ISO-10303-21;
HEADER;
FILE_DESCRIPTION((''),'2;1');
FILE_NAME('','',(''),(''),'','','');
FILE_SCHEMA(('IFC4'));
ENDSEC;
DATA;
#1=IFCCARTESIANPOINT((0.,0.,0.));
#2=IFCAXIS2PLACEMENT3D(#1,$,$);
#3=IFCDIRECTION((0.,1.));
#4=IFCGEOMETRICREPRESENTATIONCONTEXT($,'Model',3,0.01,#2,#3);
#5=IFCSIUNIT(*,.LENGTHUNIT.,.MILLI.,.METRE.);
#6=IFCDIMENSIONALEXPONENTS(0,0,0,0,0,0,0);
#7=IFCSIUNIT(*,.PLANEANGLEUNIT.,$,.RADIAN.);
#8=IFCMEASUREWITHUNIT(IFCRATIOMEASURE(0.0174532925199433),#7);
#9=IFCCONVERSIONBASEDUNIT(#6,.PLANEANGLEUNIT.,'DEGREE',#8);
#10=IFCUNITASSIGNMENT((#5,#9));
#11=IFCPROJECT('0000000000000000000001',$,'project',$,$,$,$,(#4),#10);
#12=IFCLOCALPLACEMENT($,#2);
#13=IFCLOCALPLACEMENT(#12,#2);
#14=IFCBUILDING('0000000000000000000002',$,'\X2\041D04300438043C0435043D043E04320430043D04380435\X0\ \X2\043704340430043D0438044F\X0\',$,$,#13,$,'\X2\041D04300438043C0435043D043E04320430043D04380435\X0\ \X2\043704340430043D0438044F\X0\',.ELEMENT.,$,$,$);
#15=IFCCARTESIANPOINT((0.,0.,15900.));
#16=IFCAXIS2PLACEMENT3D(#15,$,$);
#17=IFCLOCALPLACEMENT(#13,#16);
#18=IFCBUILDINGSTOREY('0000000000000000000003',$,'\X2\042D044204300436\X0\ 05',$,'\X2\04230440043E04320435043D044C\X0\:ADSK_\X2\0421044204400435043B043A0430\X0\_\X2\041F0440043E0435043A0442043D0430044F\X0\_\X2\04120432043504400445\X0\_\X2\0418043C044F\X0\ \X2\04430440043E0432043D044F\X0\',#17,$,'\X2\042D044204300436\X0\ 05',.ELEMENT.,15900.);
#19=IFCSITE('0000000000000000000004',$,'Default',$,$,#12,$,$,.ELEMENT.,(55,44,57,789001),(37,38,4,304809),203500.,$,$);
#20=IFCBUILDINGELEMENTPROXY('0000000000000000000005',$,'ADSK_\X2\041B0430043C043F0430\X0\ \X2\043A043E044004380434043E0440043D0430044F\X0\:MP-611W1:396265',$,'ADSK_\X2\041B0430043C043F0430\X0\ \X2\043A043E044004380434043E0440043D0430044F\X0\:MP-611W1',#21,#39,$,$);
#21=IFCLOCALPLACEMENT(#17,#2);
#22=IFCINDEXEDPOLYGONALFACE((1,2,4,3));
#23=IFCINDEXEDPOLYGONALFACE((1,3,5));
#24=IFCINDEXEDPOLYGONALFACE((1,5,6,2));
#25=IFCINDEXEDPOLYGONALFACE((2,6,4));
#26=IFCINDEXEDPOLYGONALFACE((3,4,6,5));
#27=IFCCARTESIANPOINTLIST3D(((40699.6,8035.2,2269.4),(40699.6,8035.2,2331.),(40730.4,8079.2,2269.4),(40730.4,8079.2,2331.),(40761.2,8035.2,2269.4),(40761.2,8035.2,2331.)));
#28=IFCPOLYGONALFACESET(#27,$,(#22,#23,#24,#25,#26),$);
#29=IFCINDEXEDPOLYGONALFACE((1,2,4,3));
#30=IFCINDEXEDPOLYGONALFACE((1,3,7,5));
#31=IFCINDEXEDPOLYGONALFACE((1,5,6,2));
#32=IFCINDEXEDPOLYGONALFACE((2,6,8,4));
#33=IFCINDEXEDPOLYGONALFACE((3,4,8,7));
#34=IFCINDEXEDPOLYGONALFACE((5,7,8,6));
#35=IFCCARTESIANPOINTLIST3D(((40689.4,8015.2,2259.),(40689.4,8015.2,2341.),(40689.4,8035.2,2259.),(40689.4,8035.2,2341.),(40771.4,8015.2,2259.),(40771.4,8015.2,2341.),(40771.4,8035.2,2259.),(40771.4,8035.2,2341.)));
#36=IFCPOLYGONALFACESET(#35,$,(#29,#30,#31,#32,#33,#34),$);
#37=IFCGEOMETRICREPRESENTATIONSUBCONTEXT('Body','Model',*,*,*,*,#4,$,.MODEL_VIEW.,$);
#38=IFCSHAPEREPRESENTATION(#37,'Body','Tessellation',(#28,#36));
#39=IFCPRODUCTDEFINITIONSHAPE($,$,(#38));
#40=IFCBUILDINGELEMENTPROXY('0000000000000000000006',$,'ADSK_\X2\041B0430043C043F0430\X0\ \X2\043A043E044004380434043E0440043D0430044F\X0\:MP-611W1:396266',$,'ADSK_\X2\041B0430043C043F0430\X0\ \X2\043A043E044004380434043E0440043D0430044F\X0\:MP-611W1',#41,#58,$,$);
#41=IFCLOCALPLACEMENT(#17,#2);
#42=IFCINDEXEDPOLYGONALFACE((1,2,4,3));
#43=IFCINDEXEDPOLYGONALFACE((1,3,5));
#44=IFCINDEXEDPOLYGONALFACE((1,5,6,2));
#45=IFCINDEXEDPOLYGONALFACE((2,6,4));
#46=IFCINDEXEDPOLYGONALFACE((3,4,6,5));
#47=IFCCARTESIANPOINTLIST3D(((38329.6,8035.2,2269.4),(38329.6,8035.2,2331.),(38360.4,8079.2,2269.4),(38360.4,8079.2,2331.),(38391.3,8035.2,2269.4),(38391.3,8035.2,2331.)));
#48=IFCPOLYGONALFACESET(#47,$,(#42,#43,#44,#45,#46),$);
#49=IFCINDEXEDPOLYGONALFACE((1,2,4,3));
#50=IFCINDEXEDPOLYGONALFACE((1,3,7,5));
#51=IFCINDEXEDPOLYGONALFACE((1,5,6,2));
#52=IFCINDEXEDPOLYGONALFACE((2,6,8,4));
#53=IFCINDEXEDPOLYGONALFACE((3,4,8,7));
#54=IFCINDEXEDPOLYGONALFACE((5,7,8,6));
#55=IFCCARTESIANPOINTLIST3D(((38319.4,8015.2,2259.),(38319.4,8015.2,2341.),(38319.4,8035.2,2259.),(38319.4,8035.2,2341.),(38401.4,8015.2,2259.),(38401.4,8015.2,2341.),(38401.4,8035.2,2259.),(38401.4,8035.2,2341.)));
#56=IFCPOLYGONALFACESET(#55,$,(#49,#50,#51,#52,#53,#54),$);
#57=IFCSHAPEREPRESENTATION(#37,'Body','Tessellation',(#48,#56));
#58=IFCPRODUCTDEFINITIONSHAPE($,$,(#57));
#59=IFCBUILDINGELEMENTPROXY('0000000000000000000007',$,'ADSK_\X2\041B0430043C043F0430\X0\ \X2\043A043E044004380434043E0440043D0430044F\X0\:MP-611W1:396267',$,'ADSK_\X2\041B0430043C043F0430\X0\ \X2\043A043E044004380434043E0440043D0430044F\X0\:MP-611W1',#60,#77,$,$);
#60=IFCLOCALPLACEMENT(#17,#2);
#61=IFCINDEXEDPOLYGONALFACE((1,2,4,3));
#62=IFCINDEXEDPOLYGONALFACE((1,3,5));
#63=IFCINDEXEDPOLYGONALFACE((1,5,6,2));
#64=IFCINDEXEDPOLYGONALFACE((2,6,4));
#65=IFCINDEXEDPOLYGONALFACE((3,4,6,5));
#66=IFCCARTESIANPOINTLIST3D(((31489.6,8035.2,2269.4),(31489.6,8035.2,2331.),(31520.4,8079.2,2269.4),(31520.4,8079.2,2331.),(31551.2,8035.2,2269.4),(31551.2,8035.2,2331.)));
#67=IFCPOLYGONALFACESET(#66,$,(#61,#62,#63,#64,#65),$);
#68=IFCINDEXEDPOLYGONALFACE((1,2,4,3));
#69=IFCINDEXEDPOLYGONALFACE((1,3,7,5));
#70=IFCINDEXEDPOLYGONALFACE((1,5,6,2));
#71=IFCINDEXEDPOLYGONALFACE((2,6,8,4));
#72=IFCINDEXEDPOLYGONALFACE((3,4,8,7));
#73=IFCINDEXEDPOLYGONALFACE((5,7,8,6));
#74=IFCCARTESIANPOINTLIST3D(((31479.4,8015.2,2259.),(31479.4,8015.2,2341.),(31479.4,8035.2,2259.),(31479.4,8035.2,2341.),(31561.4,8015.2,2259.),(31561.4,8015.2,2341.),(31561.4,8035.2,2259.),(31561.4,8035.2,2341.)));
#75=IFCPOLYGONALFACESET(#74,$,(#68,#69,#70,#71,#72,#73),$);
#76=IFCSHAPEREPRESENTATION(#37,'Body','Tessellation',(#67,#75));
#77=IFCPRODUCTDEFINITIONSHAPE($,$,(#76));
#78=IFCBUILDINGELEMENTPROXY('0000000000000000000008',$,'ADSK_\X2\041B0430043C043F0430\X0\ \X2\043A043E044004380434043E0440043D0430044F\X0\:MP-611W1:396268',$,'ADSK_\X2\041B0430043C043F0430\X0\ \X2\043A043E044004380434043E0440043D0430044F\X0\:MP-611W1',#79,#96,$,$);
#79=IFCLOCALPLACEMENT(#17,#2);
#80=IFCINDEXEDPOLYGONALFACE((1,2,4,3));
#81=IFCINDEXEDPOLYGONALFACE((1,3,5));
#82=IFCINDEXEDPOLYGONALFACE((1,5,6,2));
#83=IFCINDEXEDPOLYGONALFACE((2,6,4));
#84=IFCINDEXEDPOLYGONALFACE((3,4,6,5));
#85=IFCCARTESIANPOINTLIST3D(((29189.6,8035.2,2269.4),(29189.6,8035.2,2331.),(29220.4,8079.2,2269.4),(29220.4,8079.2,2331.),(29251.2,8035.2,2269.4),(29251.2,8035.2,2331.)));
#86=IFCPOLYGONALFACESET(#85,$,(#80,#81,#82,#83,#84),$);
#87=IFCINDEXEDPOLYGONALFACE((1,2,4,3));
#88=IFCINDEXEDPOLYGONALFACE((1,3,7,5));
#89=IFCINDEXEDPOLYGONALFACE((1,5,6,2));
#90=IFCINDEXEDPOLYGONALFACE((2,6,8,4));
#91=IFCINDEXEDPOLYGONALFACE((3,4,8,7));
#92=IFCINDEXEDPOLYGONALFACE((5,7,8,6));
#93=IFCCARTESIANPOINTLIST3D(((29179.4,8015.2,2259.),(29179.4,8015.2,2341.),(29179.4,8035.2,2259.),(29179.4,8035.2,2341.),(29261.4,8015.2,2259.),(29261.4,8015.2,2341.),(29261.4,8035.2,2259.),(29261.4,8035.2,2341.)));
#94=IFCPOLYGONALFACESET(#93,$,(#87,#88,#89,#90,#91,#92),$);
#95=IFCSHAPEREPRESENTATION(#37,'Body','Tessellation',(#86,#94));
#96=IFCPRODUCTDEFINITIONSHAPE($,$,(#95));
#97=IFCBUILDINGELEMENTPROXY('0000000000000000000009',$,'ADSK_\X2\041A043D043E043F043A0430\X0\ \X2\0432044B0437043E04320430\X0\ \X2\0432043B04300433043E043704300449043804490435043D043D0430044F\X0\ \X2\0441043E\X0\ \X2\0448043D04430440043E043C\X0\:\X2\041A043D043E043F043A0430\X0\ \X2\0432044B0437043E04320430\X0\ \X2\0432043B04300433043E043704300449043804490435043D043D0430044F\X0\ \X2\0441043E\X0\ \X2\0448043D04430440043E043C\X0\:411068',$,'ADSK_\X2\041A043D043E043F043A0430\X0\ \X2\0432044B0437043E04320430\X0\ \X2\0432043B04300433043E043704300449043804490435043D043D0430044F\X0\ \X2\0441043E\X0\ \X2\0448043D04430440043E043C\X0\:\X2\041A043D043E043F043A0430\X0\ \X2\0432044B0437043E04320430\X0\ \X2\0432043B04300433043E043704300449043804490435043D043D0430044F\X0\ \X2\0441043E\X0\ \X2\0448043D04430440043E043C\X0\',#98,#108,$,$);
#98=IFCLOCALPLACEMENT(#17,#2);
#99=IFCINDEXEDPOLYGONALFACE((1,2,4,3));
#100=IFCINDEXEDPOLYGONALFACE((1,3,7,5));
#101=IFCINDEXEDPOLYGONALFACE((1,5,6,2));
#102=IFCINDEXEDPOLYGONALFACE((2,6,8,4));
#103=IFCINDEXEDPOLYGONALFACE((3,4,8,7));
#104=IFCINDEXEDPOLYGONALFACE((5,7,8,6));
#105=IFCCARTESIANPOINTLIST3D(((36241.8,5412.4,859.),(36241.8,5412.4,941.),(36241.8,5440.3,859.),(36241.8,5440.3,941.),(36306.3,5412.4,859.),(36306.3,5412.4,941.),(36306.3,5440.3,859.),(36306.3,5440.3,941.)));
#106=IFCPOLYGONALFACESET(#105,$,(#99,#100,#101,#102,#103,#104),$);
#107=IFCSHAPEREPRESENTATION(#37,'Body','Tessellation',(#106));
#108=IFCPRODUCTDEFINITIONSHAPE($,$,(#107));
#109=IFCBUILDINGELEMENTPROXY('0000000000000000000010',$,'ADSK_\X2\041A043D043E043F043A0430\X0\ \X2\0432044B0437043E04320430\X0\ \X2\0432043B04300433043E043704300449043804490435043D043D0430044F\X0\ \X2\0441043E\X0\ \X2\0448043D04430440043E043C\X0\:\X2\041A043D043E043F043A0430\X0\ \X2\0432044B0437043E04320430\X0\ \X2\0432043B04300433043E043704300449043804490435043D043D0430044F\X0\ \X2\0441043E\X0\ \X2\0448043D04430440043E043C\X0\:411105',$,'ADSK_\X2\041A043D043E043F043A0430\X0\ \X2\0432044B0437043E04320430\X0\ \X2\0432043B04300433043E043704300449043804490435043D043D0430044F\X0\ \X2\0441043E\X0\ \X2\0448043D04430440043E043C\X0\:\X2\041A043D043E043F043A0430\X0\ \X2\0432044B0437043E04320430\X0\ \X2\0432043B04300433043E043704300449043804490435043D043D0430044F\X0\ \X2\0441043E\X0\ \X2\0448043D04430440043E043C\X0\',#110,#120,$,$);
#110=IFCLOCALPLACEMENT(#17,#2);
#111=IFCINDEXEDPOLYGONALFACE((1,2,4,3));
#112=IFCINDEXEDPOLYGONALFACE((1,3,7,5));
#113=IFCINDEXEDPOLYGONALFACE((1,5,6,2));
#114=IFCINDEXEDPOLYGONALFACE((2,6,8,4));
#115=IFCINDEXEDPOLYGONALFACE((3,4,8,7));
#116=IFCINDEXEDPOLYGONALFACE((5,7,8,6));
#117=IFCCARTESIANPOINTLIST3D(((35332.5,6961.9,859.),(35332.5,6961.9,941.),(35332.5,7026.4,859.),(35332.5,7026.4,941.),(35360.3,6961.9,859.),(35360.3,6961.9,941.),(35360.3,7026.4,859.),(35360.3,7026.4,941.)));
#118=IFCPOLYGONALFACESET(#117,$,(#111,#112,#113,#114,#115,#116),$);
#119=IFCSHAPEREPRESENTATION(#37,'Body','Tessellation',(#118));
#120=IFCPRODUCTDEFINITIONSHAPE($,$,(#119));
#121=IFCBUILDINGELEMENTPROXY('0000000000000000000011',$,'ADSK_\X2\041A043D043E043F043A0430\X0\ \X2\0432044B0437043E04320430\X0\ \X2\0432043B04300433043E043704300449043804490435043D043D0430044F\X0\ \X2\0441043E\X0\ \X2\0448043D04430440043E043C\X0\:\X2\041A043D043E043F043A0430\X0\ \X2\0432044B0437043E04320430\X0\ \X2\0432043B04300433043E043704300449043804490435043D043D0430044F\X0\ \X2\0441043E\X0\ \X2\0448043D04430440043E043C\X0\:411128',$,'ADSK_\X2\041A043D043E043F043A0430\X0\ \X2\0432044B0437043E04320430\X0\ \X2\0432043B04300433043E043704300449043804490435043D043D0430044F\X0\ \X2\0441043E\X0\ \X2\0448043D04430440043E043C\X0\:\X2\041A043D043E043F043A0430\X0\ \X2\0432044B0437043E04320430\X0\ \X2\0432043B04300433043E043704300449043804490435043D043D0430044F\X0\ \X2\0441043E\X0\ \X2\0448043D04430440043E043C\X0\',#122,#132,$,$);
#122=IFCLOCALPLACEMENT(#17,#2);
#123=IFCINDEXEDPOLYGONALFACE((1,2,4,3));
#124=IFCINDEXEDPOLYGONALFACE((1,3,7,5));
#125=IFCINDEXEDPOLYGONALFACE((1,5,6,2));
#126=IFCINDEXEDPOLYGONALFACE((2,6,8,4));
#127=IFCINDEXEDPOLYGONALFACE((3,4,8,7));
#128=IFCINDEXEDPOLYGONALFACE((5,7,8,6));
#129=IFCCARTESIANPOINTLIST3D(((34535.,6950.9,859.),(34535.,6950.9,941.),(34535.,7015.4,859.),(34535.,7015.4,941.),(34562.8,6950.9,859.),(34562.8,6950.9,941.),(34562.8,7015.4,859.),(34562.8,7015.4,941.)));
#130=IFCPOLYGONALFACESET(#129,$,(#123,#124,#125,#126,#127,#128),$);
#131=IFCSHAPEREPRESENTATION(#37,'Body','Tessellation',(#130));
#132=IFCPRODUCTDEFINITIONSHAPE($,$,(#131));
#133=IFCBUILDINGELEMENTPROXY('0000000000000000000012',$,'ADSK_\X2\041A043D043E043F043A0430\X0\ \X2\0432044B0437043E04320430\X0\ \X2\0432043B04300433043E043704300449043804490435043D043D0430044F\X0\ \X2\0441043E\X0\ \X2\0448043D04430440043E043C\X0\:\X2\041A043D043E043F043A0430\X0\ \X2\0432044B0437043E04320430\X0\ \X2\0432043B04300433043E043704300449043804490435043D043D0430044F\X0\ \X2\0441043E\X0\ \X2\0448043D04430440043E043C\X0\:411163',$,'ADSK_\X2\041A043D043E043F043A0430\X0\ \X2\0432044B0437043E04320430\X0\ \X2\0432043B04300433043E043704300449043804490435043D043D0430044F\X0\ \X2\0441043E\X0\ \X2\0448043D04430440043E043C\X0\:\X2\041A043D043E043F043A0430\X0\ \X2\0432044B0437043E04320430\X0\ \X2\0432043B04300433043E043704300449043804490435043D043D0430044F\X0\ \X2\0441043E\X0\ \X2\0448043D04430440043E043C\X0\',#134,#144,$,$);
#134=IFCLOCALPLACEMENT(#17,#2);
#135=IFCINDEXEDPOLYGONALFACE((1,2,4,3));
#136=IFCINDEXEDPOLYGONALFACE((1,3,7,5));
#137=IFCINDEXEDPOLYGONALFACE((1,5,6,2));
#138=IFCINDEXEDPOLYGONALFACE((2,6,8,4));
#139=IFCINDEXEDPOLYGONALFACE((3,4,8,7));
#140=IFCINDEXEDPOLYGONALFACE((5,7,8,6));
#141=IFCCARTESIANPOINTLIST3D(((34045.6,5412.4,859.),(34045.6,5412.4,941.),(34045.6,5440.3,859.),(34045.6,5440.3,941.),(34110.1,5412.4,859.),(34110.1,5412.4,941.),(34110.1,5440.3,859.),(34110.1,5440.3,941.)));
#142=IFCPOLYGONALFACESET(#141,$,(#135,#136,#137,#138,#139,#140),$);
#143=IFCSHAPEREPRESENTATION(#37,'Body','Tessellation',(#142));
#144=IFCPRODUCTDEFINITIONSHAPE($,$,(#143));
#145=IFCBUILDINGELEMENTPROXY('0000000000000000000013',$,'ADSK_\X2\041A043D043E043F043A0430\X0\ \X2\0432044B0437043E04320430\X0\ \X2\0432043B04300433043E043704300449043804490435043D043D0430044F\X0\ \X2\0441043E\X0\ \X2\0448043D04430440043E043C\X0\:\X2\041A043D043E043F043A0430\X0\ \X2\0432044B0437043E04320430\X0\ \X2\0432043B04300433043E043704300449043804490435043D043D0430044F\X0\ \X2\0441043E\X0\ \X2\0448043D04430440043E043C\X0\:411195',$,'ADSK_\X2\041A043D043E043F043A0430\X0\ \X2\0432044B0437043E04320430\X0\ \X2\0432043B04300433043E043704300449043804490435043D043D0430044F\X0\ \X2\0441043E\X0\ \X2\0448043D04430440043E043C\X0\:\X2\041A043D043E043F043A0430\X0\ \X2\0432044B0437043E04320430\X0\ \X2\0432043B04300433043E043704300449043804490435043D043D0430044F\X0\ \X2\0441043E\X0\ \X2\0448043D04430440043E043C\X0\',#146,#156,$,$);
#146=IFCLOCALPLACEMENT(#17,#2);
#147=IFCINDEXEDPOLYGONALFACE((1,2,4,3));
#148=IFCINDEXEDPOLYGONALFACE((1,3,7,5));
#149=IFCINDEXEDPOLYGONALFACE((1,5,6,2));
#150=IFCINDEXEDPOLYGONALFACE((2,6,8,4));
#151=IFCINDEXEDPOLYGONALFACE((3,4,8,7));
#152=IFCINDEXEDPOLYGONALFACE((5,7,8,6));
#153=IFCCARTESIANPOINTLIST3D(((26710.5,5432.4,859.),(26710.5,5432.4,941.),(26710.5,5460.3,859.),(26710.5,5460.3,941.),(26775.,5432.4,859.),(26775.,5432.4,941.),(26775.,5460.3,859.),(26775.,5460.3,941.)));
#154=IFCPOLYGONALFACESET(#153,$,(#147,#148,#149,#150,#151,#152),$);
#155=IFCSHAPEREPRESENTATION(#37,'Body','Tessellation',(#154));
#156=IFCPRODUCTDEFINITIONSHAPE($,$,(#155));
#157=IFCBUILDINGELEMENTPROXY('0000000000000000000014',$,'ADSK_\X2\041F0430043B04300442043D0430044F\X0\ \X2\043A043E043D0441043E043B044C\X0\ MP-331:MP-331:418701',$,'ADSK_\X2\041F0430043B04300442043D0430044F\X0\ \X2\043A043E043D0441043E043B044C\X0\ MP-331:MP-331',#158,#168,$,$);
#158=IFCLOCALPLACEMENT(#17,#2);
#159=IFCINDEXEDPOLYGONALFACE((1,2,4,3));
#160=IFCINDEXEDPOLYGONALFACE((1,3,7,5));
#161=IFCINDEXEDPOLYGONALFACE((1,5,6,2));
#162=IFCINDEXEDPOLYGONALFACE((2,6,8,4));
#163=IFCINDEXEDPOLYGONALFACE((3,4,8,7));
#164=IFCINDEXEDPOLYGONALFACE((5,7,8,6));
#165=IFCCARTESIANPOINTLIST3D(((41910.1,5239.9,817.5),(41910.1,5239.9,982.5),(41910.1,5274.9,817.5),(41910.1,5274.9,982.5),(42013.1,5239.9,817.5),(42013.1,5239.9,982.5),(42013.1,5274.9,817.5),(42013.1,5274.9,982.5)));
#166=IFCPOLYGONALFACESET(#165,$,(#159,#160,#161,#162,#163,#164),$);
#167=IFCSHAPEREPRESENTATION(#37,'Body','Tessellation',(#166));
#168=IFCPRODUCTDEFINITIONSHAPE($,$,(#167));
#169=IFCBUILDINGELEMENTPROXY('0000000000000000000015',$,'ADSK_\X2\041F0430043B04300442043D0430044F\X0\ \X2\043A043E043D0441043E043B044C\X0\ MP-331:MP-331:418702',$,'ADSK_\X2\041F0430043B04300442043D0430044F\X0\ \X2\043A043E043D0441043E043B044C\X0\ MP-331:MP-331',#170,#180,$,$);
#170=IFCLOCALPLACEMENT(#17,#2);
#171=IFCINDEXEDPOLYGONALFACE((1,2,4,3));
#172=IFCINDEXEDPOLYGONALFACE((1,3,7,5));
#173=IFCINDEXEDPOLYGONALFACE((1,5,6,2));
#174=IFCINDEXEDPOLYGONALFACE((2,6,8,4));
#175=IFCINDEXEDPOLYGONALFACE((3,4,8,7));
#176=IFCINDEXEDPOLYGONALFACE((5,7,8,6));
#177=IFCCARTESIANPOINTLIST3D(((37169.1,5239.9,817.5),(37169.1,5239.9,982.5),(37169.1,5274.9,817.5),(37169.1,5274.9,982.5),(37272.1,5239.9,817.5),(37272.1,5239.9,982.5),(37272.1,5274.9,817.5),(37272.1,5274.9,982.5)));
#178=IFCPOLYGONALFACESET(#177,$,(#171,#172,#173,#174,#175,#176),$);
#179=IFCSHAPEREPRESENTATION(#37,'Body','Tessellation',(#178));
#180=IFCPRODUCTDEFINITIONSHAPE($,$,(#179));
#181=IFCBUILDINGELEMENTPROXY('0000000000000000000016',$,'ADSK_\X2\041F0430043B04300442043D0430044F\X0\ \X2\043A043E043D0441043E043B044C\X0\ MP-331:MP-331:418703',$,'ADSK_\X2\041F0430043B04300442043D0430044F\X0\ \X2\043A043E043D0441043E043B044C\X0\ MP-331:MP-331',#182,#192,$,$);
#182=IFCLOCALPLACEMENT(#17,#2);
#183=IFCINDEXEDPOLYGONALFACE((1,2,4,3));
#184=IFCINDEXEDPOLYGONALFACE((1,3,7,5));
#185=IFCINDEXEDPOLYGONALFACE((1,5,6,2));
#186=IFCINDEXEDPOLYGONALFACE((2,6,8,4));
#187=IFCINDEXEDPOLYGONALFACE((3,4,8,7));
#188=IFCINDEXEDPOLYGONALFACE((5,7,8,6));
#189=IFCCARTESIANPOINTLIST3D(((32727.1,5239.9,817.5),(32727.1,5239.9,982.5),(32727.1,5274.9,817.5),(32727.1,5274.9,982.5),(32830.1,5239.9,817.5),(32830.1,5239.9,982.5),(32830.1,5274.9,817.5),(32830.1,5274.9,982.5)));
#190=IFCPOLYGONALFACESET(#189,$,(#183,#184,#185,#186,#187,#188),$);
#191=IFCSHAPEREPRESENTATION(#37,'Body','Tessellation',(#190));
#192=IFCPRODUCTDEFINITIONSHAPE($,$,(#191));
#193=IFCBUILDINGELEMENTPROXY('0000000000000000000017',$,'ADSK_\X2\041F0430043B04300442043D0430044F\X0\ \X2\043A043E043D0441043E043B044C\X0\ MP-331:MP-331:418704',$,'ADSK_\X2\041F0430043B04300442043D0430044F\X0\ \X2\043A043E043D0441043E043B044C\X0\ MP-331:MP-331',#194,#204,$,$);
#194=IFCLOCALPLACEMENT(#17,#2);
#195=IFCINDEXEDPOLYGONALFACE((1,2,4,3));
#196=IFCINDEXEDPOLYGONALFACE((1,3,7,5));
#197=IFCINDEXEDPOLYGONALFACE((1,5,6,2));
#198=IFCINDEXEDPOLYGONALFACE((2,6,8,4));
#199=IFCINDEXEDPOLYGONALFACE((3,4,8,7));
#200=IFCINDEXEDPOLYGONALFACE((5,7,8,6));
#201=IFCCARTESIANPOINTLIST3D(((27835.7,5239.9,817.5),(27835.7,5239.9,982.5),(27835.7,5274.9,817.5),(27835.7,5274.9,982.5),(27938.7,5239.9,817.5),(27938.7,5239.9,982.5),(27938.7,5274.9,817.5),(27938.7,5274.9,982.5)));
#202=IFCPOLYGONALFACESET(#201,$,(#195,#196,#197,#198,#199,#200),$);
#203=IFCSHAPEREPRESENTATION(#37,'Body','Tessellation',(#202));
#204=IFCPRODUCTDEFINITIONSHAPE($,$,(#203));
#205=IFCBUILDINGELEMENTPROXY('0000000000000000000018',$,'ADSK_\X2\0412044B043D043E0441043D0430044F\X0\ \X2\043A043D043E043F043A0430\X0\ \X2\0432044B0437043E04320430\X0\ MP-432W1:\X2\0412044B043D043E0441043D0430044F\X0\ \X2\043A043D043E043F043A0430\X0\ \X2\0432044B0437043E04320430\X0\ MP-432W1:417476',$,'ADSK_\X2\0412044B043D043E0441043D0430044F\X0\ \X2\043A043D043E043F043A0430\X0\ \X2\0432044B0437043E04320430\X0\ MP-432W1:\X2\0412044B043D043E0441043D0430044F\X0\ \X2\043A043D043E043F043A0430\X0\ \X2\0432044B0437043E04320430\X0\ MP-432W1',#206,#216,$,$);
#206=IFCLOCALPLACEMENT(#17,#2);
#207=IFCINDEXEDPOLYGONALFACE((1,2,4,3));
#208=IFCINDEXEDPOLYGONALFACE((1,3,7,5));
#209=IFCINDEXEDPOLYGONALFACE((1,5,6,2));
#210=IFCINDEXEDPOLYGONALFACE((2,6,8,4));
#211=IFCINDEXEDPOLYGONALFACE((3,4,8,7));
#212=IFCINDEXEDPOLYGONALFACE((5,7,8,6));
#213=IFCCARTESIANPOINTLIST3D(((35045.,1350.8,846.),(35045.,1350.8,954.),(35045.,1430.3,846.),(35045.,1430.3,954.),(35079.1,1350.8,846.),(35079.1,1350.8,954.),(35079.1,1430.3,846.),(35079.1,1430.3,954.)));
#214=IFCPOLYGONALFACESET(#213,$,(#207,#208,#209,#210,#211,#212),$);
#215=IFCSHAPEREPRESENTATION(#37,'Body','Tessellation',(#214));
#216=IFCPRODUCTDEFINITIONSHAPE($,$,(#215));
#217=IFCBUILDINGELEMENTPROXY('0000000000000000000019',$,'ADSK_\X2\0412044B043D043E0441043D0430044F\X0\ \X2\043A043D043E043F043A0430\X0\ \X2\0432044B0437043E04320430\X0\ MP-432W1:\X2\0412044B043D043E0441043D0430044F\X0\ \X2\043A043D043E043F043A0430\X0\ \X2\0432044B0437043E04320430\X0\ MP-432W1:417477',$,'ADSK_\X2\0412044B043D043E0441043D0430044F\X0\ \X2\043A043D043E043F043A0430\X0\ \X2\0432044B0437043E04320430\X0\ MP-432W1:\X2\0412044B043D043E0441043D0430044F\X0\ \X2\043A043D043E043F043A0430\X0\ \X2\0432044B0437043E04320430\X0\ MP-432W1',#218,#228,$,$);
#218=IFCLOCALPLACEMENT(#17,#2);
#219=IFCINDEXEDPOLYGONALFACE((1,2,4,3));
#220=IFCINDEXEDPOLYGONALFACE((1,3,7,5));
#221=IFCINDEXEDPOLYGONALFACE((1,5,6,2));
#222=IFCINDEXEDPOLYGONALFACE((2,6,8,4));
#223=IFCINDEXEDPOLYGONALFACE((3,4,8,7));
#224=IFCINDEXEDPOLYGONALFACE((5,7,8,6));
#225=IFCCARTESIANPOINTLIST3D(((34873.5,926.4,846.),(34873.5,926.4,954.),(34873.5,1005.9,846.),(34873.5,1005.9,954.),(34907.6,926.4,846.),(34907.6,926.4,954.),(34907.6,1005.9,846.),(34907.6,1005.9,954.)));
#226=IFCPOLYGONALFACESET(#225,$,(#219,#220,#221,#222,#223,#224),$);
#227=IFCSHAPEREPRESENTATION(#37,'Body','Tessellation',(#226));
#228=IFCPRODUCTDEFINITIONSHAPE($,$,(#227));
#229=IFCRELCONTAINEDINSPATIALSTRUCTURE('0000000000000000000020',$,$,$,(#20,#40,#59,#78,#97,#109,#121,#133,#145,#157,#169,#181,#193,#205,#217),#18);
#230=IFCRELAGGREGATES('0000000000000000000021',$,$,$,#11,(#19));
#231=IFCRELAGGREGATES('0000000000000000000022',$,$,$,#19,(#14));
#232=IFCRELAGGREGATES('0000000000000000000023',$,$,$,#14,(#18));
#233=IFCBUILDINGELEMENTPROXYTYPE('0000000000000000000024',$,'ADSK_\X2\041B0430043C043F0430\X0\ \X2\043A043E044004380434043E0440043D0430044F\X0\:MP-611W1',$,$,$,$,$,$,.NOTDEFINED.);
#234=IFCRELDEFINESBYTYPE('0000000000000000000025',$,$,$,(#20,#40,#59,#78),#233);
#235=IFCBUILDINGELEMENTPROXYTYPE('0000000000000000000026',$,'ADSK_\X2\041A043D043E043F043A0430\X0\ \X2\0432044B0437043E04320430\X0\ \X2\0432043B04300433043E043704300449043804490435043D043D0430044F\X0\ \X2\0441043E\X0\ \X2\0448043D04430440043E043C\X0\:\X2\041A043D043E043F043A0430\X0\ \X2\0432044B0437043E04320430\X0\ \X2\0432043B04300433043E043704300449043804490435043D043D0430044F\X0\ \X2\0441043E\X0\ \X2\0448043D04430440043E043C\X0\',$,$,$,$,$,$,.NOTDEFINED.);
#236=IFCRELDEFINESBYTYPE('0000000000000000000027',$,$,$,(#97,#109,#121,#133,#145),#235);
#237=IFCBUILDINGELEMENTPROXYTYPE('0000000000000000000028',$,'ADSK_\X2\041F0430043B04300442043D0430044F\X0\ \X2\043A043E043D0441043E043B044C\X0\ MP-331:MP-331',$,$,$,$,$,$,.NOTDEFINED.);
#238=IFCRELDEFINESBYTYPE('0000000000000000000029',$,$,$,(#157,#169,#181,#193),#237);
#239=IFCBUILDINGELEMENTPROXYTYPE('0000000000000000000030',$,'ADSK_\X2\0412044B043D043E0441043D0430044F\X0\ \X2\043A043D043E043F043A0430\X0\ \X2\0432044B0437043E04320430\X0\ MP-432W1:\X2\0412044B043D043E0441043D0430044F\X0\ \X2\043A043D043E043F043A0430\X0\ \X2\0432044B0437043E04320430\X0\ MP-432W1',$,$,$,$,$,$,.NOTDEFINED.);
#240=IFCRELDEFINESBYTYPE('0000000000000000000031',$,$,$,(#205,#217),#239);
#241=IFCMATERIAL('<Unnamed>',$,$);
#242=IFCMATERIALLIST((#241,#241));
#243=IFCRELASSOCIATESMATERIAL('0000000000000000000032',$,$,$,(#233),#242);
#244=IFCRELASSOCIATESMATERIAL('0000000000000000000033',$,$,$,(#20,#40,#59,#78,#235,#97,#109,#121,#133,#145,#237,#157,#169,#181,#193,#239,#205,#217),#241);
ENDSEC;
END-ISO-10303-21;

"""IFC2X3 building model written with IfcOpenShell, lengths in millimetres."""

from ifc_helpers import new_model, entity, si_unit, converted_unit, direction, frame, origin, origin_2d_with_axis, place, context, subcontext, project, spatial, polyline, rectangle, outline, extrude, source, transform, mapped, material, material_list, type_object, type_shapes, element, save


model = new_model("IFC2X3")

# Units and contexts
model_context = context("Model", 3, precision=0.01, world=origin(), true_north=direction((0.0, 1.0)))
body_context = subcontext(model_context, "Body", "Model", "MODEL_VIEW")
ifc_project = project(units=[si_unit("LENGTHUNIT", "METRE", prefix="MILLI"), converted_unit("PLANEANGLEUNIT", "DEGREE", entity("IfcRatioMeasure", 0.0174532925199433), si_unit("PLANEANGLEUNIT", "RADIAN"), dimensions=[0, 0, 0, 0, 0, 0, 0])], contexts=[model_context])

# Site, building, storey
site_placement = place(None, origin())
site = spatial("IfcSite", under=ifc_project, at=site_placement, Name="Default", CompositionType="ELEMENT", RefLatitude=(55, 44, 57, 789001), RefLongitude=(37, 38, 4, 304809), RefElevation=203500.0)
building_placement = place(site_placement, origin())
building = spatial("IfcBuilding", under=site, at=building_placement, Name="Наименование здания", LongName="Наименование здания", CompositionType="ELEMENT")
storey_placement = place(building_placement, frame((0.0, 0.0, 15900.0)))
storey = spatial("IfcBuildingStorey", under=building, at=storey_placement, Name="Этаж 05", ObjectType="Уровень:ADSK_Стрелка_Проектная_Вверх_Имя уровня", LongName="Этаж 05", CompositionType="ELEMENT", Elevation=15900.0)

# Building element proxies
ifc_material = material(Name="<Unnamed>")
ifc_material_list = material_list([ifc_material, ifc_material])
building_element_proxy_type_1 = type_object("IfcBuildingElementProxyType", Name="ADSK_Лампа коридорная:MP-611W1", PredefinedType="NOTDEFINED", material=ifc_material_list)
shared_shape_1 = source(origin(), body_context, "Body", "SweptSolid", [
    extrude(outline(polyline([(-30.8, -14.7), (30.8, -14.7), (0.0, 29.3), (-30.8, -14.7)])), frame((0.0, -2.7, -30.6), z_axis=(0.0, 0.0, 1.0), x_axis=(-1.0, 0.0, 0.0)), (0.0, 0.0, 1.0), 61.6),
    extrude(rectangle(XDim=82.0, YDim=20.0, at=origin_2d_with_axis()), frame((0.0, 22.0, -41.0), z_axis=(0.0, 0.0, 1.0), x_axis=(-1.0, 0.0, 0.0)), (0.0, 0.0, 1.0), 82.0),
])
type_shapes(building_element_proxy_type_1, [shared_shape_1])
for number, where, z_axis, x_axis, name in (
    (1, (40730.4, 8047.1, 2300.0), (0.0, 0.0, 1.0), (-1.0, 0.0, 0.0), "ADSK_Лампа коридорная:MP-611W1:396265"),
    (2, (38360.4, 8047.1, 2300.0), (0.0, 0.0, 1.0), (-1.0, 0.0, 0.0), "ADSK_Лампа коридорная:MP-611W1:396266"),
    (3, (31520.4, 8047.1, 2300.0), (0.0, 0.0, 1.0), (-1.0, 0.0, 0.0), "ADSK_Лампа коридорная:MP-611W1:396267"),
    (4, (29220.4, 8047.1, 2300.0), (0.0, 0.0, 1.0), (-1.0, 0.0, 0.0), "ADSK_Лампа коридорная:MP-611W1:396268"),
):
    element("IfcBuildingElementProxy", number, at=place(storey_placement, frame(where, z_axis=z_axis, x_axis=x_axis)), inside=storey, type_object=building_element_proxy_type_1, material=ifc_material, Name=name, ObjectType="ADSK_Лампа коридорная:MP-611W1", context=body_context, shape_type="MappedRepresentation", body=[
        mapped(shared_shape_1, transform((0.0, 0.0, 0.0), scale=1.0)),
    ])
building_element_proxy_type_2 = type_object("IfcBuildingElementProxyType", Name="ADSK_Кнопка вызова влагозащищенная со шнуром:Кнопка вызова влагозащищенная со шнуром", PredefinedType="NOTDEFINED", material=ifc_material)
shared_shape_2 = source(origin(), body_context, "Body", "SweptSolid", [
    extrude(rectangle(XDim=64.5, YDim=27.8, at=origin_2d_with_axis()), frame((32.2, 13.9, 0.0), z_axis=(0.0, 0.0, 1.0), x_axis=(-1.0, 0.0, 0.0)), (0.0, 0.0, 1.0), 82.0),
])
type_shapes(building_element_proxy_type_2, [shared_shape_2])
for number, where, z_axis, x_axis, name in (
    (5, (36306.3, 5440.3, 859.0), (0.0, 0.0, 1.0), (-1.0, 0.0, 0.0), "ADSK_Кнопка вызова влагозащищенная со шнуром:Кнопка вызова влагозащищенная со шнуром:411068"),
    (6, (35360.3, 6961.9, 859.0), (0.0, 0.0, 1.0), (0.0, 1.0, 0.0), "ADSK_Кнопка вызова влагозащищенная со шнуром:Кнопка вызова влагозащищенная со шнуром:411105"),
    (7, (34535.0, 7015.4, 859.0), (0.0, 0.0, 1.0), (0.0, -1.0, 0.0), "ADSK_Кнопка вызова влагозащищенная со шнуром:Кнопка вызова влагозащищенная со шнуром:411128"),
    (8, (34110.1, 5440.3, 859.0), (0.0, 0.0, 1.0), (-1.0, 0.0, 0.0), "ADSK_Кнопка вызова влагозащищенная со шнуром:Кнопка вызова влагозащищенная со шнуром:411163"),
    (9, (26775.0, 5460.3, 859.0), (0.0, 0.0, 1.0), (-1.0, 0.0, 0.0), "ADSK_Кнопка вызова влагозащищенная со шнуром:Кнопка вызова влагозащищенная со шнуром:411195"),
):
    element("IfcBuildingElementProxy", number, at=place(storey_placement, frame(where, z_axis=z_axis, x_axis=x_axis)), inside=storey, type_object=building_element_proxy_type_2, material=ifc_material, Name=name, ObjectType="ADSK_Кнопка вызова влагозащищенная со шнуром:Кнопка вызова влагозащищенная со шнуром", context=body_context, shape_type="MappedRepresentation", body=[
        mapped(shared_shape_2, transform((0.0, 0.0, 0.0), scale=1.0)),
    ])
building_element_proxy_type_3 = type_object("IfcBuildingElementProxyType", Name="ADSK_Палатная консоль MP-331:MP-331", PredefinedType="NOTDEFINED", material=ifc_material)
shared_shape_3 = source(origin(), body_context, "Body", "SweptSolid", [
    extrude(rectangle(XDim=103.0, YDim=35.0, at=origin_2d_with_axis()), frame((0.0, 14.5, -82.5), z_axis=(0.0, 0.0, 1.0), x_axis=(-1.0, 0.0, 0.0)), (0.0, 0.0, 1.0), 165.0),
])
type_shapes(building_element_proxy_type_3, [shared_shape_3])
for number, where, name in (
    (10, (41961.6, 5242.9, 900.0), "ADSK_Палатная консоль MP-331:MP-331:418701"),
    (11, (37220.6, 5242.9, 900.0), "ADSK_Палатная консоль MP-331:MP-331:418702"),
    (12, (32778.6, 5242.9, 900.0), "ADSK_Палатная консоль MP-331:MP-331:418703"),
    (13, (27887.2, 5242.9, 900.0), "ADSK_Палатная консоль MP-331:MP-331:418704"),
):
    element("IfcBuildingElementProxy", number, at=place(storey_placement, frame(where)), inside=storey, type_object=building_element_proxy_type_3, material=ifc_material, Name=name, ObjectType="ADSK_Палатная консоль MP-331:MP-331", context=body_context, shape_type="MappedRepresentation", body=[
        mapped(shared_shape_3, transform((0.0, 0.0, 0.0), scale=1.0)),
    ])
building_element_proxy_type_4 = type_object("IfcBuildingElementProxyType", Name="ADSK_Выносная кнопка вызова MP-432W1:Выносная кнопка вызова MP-432W1", PredefinedType="NOTDEFINED", material=ifc_material)
shared_shape_4 = source(origin(), body_context, "Body", "SweptSolid", [
    extrude(rectangle(XDim=79.5, YDim=34.1, at=origin_2d_with_axis()), frame((0.0, 15.0, -54.0), z_axis=(0.0, 0.0, 1.0), x_axis=(-1.0, 0.0, 0.0)), (0.0, 0.0, 1.0), 108.0),
])
type_shapes(building_element_proxy_type_4, [shared_shape_4])
for number, where, z_axis, x_axis, name in (
    (14, (35077.0, 1390.5, 900.0), (0.0, 0.0, 1.0), (0.0, 1.0, 0.0), "ADSK_Выносная кнопка вызова MP-432W1:Выносная кнопка вызова MP-432W1:417476"),
    (15, (34875.6, 966.2, 900.0), (0.0, 0.0, 1.0), (0.0, -1.0, 0.0), "ADSK_Выносная кнопка вызова MP-432W1:Выносная кнопка вызова MP-432W1:417477"),
):
    element("IfcBuildingElementProxy", number, at=place(storey_placement, frame(where, z_axis=z_axis, x_axis=x_axis)), inside=storey, type_object=building_element_proxy_type_4, material=ifc_material, Name=name, ObjectType="ADSK_Выносная кнопка вызова MP-432W1:Выносная кнопка вызова MP-432W1", context=body_context, shape_type="MappedRepresentation", body=[
        mapped(shared_shape_4, transform((0.0, 0.0, 0.0), scale=1.0)),
    ])

save(model, "model.ifc")
